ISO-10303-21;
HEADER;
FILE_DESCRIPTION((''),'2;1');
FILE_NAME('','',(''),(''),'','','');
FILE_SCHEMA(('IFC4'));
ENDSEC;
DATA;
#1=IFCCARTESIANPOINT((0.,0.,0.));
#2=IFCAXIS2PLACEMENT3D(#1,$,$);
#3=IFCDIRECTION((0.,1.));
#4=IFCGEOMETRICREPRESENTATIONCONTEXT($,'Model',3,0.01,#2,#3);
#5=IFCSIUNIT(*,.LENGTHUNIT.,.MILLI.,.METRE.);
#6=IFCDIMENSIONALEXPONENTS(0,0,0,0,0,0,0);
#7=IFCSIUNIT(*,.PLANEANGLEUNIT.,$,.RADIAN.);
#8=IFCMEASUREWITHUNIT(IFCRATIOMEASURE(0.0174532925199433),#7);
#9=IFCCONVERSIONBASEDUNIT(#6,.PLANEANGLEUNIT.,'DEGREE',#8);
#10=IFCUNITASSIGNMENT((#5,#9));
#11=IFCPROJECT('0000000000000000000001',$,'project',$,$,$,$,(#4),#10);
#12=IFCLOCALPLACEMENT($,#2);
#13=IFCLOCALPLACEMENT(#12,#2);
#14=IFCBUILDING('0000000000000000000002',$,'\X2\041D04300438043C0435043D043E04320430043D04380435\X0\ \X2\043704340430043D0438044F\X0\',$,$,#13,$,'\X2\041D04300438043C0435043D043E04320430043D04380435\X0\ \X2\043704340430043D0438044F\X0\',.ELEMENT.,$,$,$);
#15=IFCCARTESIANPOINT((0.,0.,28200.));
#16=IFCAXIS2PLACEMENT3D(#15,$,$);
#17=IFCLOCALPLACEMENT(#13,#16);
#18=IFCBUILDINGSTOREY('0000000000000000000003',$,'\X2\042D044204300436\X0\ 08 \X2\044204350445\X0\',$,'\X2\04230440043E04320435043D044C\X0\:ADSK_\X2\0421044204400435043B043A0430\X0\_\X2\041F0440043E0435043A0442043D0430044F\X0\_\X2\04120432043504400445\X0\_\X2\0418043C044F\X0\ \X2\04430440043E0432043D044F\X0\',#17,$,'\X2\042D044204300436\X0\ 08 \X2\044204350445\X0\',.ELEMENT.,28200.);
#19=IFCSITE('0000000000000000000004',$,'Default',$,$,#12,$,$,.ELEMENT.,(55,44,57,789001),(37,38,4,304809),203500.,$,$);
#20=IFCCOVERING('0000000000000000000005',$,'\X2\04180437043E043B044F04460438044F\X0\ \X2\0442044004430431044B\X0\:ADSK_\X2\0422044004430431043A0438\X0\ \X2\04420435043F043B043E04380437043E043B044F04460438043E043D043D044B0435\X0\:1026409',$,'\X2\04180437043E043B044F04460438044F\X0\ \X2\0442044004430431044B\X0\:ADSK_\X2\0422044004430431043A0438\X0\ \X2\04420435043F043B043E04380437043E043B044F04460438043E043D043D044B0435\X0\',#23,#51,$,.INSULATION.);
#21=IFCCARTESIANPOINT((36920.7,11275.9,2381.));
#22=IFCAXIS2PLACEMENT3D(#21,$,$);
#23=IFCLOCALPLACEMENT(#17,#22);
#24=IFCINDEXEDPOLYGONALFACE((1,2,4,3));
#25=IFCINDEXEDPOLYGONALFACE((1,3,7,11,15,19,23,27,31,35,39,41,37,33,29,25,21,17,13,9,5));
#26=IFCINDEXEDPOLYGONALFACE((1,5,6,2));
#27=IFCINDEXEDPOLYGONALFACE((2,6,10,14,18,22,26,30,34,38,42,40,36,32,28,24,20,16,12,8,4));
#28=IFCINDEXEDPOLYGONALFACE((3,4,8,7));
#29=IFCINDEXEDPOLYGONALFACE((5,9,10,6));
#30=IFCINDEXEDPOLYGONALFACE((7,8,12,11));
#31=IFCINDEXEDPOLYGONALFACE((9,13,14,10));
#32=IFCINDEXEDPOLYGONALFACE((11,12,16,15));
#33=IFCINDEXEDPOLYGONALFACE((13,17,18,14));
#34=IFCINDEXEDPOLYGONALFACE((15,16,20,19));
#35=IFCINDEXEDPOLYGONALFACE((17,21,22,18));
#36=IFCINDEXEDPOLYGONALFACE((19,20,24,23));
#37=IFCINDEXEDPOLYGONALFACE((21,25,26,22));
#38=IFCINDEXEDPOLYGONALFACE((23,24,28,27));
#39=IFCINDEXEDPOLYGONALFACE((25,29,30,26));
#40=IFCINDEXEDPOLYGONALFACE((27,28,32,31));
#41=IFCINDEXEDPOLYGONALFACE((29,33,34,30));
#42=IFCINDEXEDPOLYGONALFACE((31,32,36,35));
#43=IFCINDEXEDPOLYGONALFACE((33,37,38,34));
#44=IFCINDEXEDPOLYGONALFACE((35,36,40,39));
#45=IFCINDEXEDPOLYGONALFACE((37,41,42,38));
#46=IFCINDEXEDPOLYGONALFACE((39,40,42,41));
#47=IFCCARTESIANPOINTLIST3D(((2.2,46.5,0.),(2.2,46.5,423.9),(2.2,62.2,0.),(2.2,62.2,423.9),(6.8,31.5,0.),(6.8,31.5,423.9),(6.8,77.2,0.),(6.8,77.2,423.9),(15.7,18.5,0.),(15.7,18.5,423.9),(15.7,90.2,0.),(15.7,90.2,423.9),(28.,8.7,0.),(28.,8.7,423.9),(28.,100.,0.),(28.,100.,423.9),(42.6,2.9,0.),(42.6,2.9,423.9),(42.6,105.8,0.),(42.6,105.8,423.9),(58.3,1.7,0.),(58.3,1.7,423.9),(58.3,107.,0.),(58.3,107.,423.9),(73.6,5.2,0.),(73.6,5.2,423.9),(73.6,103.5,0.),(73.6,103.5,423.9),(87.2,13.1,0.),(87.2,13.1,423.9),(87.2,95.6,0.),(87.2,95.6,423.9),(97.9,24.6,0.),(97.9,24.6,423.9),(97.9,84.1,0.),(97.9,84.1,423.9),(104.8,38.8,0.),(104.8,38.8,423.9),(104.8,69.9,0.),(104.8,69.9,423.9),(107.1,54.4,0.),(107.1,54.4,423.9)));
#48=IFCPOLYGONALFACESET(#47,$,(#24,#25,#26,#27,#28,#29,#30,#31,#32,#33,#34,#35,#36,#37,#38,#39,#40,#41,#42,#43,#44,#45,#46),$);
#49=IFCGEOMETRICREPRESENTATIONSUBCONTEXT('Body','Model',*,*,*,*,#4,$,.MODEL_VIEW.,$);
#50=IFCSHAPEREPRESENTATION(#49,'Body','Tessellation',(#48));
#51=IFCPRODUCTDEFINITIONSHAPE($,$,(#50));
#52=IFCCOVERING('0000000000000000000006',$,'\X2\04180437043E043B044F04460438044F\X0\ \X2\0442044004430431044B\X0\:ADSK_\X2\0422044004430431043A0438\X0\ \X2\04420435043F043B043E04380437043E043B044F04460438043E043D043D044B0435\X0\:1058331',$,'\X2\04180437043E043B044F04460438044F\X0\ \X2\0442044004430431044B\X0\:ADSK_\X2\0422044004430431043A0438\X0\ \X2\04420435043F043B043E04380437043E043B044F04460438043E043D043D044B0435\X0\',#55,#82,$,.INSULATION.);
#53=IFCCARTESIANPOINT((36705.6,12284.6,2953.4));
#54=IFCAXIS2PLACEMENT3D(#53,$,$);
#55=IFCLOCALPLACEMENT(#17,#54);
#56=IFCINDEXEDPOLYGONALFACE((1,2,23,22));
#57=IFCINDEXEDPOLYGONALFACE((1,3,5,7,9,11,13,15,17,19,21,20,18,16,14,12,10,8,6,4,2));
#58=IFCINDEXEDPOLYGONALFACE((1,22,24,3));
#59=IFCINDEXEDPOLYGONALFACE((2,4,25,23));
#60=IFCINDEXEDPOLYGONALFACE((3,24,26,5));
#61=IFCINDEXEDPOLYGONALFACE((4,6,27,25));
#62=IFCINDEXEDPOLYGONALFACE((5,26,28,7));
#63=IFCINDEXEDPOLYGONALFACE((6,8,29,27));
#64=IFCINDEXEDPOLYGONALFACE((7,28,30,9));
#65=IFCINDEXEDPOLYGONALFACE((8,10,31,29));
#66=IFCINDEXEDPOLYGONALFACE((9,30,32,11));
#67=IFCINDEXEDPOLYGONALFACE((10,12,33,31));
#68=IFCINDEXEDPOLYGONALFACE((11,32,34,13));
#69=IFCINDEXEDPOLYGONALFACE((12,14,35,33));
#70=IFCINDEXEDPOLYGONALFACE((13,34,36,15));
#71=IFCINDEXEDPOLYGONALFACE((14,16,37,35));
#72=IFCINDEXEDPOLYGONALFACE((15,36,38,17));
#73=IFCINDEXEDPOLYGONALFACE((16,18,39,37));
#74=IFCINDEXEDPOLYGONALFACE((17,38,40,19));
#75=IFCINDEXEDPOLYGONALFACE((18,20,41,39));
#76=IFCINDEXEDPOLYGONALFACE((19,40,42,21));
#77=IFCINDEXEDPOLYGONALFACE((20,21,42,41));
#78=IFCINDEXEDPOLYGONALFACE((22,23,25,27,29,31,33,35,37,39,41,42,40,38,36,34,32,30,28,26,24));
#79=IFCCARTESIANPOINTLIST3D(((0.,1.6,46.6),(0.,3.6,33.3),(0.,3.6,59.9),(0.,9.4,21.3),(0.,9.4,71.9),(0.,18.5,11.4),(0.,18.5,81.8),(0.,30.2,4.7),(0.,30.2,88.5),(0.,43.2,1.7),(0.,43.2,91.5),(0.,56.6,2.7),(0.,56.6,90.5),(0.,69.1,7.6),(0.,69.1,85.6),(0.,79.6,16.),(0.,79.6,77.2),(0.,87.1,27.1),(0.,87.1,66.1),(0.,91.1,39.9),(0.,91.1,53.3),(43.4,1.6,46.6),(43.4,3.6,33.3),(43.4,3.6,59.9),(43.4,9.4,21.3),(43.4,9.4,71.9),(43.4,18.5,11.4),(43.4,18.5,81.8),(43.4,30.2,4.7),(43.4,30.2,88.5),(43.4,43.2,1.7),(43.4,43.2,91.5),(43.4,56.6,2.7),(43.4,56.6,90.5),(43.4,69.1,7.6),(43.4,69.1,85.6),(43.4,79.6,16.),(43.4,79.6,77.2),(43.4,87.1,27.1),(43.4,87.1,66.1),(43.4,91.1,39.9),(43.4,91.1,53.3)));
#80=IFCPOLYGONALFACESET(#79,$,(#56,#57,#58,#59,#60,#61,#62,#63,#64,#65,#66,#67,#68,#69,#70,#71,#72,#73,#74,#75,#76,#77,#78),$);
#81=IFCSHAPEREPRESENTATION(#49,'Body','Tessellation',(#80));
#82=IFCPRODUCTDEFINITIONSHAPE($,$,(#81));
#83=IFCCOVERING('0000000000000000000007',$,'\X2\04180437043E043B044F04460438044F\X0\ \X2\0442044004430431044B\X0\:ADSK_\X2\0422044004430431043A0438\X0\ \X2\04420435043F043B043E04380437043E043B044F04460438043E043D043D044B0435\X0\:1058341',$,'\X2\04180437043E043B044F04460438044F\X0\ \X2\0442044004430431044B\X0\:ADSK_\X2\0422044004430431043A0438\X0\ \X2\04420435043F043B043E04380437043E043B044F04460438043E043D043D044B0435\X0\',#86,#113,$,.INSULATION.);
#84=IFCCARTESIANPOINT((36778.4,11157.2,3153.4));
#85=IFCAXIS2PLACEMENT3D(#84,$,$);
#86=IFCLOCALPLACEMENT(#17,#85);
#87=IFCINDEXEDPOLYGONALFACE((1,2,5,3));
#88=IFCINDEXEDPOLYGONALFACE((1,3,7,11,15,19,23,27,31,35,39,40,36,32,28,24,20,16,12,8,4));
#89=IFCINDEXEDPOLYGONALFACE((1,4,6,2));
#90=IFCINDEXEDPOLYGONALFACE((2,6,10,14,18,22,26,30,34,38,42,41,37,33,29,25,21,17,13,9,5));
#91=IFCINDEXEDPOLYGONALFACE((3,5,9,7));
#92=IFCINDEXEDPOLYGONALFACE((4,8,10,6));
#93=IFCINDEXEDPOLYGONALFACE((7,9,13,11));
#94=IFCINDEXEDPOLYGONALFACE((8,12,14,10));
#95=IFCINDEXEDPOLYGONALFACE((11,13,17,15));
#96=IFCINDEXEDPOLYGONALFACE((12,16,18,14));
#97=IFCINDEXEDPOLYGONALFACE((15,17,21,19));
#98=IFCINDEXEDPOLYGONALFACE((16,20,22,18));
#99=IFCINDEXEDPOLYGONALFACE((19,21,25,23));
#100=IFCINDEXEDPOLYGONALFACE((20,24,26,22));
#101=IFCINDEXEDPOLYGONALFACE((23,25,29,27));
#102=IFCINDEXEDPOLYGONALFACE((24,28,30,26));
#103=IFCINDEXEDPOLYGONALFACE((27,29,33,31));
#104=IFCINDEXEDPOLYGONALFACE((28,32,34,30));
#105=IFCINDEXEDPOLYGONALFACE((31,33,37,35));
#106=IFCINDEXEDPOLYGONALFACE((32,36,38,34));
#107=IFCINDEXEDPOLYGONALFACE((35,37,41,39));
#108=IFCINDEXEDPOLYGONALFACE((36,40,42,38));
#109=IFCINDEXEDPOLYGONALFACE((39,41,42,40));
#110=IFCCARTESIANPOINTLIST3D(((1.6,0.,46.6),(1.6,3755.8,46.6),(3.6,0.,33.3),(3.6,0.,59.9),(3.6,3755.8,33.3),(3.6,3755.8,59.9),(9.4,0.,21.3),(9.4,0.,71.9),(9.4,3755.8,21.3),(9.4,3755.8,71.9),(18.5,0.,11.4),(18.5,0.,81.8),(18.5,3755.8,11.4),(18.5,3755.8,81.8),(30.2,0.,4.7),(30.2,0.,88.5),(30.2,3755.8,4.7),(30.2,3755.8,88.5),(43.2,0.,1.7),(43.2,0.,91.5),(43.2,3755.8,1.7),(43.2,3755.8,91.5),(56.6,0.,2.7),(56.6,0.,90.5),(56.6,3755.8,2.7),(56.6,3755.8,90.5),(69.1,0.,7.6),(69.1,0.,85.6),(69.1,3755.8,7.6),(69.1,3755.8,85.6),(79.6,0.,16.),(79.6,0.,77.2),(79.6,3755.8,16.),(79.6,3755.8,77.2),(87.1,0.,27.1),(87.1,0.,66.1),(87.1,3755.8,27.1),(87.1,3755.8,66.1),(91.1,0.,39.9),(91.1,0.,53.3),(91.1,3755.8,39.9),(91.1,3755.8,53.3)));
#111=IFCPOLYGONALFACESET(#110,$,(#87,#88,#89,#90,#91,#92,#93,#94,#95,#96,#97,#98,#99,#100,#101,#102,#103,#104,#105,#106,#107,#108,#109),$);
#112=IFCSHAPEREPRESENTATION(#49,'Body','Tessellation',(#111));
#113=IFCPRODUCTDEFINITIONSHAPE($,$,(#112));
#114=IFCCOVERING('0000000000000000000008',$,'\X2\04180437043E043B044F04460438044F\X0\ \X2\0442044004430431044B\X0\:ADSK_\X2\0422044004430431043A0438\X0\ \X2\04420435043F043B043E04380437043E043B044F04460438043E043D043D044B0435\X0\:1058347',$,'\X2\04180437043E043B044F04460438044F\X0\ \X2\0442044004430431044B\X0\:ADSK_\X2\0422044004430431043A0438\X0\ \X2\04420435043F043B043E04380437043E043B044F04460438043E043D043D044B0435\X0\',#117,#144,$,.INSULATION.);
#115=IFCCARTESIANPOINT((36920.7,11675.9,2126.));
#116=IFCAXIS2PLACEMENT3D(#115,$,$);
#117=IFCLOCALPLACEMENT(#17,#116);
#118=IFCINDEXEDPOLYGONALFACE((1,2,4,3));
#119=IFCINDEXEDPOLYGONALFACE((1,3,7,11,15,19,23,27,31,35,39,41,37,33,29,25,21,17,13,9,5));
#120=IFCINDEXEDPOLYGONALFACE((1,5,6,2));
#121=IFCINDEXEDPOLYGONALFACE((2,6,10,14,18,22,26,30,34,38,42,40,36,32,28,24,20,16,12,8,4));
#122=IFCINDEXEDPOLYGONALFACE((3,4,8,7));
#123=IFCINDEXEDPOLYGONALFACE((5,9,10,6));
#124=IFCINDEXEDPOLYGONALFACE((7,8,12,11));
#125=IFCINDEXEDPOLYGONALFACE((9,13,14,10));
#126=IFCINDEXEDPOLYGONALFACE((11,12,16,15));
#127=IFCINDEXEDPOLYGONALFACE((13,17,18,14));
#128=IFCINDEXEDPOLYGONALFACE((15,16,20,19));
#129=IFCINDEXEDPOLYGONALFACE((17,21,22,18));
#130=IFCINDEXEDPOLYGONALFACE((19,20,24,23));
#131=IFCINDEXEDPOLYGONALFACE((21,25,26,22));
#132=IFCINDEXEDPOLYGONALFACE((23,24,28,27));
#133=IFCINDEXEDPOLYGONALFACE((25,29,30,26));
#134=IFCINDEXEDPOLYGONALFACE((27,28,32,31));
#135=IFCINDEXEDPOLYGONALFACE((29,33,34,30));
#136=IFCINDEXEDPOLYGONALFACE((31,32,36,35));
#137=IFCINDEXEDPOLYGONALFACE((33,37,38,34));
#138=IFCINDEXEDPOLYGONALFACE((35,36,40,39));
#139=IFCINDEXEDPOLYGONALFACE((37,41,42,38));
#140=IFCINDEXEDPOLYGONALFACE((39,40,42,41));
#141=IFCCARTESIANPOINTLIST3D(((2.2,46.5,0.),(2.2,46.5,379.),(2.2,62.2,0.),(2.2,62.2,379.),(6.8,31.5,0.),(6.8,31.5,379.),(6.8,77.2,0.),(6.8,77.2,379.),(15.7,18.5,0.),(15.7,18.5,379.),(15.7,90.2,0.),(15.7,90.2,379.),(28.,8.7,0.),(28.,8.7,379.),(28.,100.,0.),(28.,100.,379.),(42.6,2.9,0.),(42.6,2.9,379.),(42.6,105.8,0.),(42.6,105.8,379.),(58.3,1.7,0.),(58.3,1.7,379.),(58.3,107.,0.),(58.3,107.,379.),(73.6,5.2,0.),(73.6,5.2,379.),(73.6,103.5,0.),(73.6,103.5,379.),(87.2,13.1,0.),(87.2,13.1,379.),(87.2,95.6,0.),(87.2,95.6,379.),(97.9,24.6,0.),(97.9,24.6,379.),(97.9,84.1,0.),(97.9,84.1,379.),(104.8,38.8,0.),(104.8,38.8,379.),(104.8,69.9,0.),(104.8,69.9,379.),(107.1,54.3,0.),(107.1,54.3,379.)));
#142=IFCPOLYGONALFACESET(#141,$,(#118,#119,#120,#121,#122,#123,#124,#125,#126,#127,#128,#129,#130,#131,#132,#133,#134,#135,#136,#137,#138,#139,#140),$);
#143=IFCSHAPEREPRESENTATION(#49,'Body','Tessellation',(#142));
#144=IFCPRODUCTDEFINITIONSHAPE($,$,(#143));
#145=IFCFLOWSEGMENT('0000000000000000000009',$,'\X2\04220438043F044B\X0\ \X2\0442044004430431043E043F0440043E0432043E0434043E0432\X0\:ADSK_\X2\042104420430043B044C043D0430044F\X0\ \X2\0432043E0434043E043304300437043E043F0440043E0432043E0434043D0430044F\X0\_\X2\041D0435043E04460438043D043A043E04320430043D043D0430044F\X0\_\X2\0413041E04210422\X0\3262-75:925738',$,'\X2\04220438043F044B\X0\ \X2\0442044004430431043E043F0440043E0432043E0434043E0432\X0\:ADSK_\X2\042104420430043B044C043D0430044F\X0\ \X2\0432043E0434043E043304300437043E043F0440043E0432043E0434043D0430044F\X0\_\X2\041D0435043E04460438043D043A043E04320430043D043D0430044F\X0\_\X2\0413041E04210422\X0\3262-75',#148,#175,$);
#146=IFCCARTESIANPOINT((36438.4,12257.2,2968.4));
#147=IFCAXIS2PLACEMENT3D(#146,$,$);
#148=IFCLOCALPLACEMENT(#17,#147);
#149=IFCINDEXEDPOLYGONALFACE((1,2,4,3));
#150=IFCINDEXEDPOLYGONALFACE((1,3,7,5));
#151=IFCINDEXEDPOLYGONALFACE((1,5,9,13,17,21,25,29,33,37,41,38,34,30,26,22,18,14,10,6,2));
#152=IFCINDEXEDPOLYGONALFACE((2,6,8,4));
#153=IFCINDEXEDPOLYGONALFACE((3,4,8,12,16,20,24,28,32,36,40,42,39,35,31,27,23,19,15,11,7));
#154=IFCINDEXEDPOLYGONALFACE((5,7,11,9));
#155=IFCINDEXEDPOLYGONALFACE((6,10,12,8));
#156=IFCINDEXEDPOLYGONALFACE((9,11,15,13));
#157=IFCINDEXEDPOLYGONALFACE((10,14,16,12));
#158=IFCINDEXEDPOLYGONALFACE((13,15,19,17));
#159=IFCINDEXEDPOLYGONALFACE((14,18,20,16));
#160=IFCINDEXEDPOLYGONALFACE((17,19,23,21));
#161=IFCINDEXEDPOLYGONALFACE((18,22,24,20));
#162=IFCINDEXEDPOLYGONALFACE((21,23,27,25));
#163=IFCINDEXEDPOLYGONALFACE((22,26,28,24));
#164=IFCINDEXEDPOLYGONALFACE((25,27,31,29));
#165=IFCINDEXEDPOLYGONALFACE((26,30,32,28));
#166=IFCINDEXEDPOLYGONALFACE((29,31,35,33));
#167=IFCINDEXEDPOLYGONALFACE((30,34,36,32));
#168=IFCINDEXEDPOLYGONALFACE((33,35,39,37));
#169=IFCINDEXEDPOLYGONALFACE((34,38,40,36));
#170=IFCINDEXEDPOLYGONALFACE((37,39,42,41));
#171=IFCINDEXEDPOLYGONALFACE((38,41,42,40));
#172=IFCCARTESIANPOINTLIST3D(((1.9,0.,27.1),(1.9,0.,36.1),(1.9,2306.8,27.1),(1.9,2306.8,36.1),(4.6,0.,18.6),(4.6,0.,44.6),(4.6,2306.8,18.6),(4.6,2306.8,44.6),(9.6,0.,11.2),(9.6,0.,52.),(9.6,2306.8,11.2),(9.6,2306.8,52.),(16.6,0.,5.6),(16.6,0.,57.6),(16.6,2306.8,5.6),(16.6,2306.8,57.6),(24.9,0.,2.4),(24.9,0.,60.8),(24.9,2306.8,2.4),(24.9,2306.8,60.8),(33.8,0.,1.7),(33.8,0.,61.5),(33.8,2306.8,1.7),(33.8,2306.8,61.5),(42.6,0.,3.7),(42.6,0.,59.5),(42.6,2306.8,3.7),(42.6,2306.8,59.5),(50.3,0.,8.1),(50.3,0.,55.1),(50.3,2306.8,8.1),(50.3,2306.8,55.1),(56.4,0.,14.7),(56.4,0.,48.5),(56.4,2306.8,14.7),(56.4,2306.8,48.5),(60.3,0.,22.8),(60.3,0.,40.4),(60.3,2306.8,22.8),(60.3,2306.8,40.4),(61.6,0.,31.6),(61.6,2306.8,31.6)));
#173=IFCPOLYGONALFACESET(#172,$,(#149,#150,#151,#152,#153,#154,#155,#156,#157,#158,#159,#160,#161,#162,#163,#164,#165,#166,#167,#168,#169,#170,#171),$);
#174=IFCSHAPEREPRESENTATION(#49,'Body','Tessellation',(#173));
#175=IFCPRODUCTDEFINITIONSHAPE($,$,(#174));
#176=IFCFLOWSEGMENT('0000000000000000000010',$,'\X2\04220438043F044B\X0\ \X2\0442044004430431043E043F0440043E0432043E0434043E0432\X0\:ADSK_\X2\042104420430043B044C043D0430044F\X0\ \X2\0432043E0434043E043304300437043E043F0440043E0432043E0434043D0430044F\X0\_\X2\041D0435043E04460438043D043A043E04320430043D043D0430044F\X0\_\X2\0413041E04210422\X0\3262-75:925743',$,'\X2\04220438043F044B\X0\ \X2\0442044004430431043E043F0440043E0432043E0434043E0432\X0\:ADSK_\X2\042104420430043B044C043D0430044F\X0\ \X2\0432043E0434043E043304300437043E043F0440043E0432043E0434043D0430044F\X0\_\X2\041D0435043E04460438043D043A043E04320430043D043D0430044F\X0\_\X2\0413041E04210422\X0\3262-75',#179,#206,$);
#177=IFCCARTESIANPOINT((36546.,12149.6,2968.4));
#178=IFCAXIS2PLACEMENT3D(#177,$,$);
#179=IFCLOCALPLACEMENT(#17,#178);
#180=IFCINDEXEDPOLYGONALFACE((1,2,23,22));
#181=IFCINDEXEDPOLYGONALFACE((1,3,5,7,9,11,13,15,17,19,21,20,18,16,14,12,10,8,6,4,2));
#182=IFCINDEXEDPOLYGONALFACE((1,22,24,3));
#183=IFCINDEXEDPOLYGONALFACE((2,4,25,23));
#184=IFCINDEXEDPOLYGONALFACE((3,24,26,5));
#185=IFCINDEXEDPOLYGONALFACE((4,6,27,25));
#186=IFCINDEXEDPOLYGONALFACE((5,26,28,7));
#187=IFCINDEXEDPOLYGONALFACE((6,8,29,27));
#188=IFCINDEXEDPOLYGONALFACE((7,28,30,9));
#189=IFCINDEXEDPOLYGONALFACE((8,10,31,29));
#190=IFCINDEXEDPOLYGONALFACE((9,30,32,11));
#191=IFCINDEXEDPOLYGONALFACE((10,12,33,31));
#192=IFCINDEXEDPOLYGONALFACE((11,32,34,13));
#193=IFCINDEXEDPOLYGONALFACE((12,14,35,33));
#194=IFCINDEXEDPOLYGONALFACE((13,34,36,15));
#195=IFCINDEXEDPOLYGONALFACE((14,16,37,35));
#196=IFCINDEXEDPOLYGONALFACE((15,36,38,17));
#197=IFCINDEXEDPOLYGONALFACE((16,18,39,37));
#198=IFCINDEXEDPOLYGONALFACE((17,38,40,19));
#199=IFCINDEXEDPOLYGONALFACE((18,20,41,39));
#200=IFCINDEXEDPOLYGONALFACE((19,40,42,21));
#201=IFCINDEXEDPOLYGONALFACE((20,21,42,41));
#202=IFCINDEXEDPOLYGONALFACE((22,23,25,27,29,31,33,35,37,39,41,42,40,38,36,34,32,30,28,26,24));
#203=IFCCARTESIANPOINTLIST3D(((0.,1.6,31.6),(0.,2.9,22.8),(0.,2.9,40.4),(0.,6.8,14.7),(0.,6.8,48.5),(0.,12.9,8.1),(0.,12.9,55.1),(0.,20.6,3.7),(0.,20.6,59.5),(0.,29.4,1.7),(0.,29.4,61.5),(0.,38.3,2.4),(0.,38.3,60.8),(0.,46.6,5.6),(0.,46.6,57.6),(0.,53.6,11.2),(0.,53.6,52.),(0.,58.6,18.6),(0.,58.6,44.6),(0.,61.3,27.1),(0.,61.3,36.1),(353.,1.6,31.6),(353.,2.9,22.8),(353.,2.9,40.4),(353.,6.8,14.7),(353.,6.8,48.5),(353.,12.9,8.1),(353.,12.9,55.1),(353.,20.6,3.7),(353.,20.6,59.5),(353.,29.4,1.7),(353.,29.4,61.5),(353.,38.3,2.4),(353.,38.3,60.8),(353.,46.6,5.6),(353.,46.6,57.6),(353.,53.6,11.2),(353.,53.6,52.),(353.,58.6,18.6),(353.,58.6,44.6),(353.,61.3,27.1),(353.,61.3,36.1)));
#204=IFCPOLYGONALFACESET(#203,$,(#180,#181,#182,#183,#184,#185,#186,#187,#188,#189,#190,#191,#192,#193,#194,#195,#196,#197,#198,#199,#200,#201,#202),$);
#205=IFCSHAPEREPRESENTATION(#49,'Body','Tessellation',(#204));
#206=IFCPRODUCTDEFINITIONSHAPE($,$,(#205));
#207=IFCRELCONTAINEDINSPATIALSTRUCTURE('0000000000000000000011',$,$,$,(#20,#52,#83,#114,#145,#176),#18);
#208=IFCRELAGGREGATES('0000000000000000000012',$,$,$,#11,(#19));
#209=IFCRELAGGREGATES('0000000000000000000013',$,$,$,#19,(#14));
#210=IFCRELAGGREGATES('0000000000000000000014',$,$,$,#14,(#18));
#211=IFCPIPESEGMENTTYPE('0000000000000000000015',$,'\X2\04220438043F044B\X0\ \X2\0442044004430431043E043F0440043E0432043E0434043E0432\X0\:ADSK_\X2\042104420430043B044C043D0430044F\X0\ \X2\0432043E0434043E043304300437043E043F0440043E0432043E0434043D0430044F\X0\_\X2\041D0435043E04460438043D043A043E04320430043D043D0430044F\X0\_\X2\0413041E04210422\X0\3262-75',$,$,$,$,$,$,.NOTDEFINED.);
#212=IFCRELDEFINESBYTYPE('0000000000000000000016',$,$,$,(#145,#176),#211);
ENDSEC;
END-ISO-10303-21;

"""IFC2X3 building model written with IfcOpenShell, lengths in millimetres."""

from ifc_helpers import new_model, entity, si_unit, converted_unit, direction, frame, origin, origin_2d_with_axis, place, context, subcontext, project, spatial, circle, extrude, type_object, element, save


model = new_model("IFC2X3")

# Units and contexts
model_context = context("Model", 3, precision=0.01, world=origin(), true_north=direction((0.0, 1.0)))
body_context = subcontext(model_context, "Body", "Model", "MODEL_VIEW")
ifc_project = project(units=[si_unit("LENGTHUNIT", "METRE", prefix="MILLI"), converted_unit("PLANEANGLEUNIT", "DEGREE", entity("IfcRatioMeasure", 0.0174532925199433), si_unit("PLANEANGLEUNIT", "RADIAN"), dimensions=[0, 0, 0, 0, 0, 0, 0])], contexts=[model_context])

# Site, building, storey
site_placement = place(None, origin())
site = spatial("IfcSite", under=ifc_project, at=site_placement, Name="Default", CompositionType="ELEMENT", RefLatitude=(55, 44, 57, 789001), RefLongitude=(37, 38, 4, 304809), RefElevation=203500.0)
building_placement = place(site_placement, origin())
building = spatial("IfcBuilding", under=site, at=building_placement, Name="Наименование здания", LongName="Наименование здания", CompositionType="ELEMENT")
storey_placement = place(building_placement, frame((0.0, 0.0, 28200.0)))
storey = spatial("IfcBuildingStorey", under=building, at=storey_placement, Name="Этаж 08 тех", ObjectType="Уровень:ADSK_Стрелка_Проектная_Вверх_Имя уровня", LongName="Этаж 08 тех", CompositionType="ELEMENT", Elevation=28200.0)

# Coverings
covering_1_placement = place(storey_placement, frame((36920.7, 11275.9, 2381.0)))
element("IfcCovering", 1, at=covering_1_placement, inside=storey, Name="Изоляция трубы:ADSK_Трубки теплоизоляционные:1026409", ObjectType="Изоляция трубы:ADSK_Трубки теплоизоляционные", PredefinedType="INSULATION", context=body_context, shape_type="SweptSolid", body=[
    extrude(circle(Radius=52.8, at=origin_2d_with_axis()), frame((54.4, 54.4, 0.0)), (0.0, 0.0, 1.0), 423.9),
])
covering_2_placement = place(storey_placement, frame((36705.6, 12284.6, 2953.4)))
element("IfcCovering", 2, at=covering_2_placement, inside=storey, Name="Изоляция трубы:ADSK_Трубки теплоизоляционные:1058331", ObjectType="Изоляция трубы:ADSK_Трубки теплоизоляционные", PredefinedType="INSULATION", context=body_context, shape_type="SweptSolid", body=[
    extrude(circle(Radius=45.0, at=origin_2d_with_axis()), frame((0.0, 46.6, 46.6), z_axis=(1.0, 0.0, 0.0), x_axis=(0.0, -1.0, 0.0)), (0.0, 0.0, 1.0), 43.4),
])
covering_3_placement = place(storey_placement, frame((36778.4, 11157.2, 3153.4)))
element("IfcCovering", 3, at=covering_3_placement, inside=storey, Name="Изоляция трубы:ADSK_Трубки теплоизоляционные:1058341", ObjectType="Изоляция трубы:ADSK_Трубки теплоизоляционные", PredefinedType="INSULATION", context=body_context, shape_type="SweptSolid", body=[
    extrude(circle(Radius=45.0, at=origin_2d_with_axis()), frame((46.6, 0.0, 46.6), z_axis=(0.0, 1.0, 0.0), x_axis=(-1.0, 0.0, 0.0)), (0.0, 0.0, 1.0), 3755.8),
])
covering_4_placement = place(storey_placement, frame((36920.7, 11675.9, 2126.0)))
element("IfcCovering", 4, at=covering_4_placement, inside=storey, Name="Изоляция трубы:ADSK_Трубки теплоизоляционные:1058347", ObjectType="Изоляция трубы:ADSK_Трубки теплоизоляционные", PredefinedType="INSULATION", context=body_context, shape_type="SweptSolid", body=[
    extrude(circle(Radius=52.8, at=origin_2d_with_axis()), frame((54.4, 54.4, 0.0)), (0.0, 0.0, 1.0), 379.0),
])

# Flow segments
pipe_segment_type = type_object("IfcPipeSegmentType", Name="Типы трубопроводов:ADSK_Стальная водогазопроводная_Неоцинкованная_ГОСТ3262-75", PredefinedType="NOTDEFINED")
flow_segment_1_placement = place(storey_placement, frame((36438.4, 12257.2, 2968.4)))
element("IfcFlowSegment", 5, at=flow_segment_1_placement, inside=storey, type_object=pipe_segment_type, Name="Типы трубопроводов:ADSK_Стальная водогазопроводная_Неоцинкованная_ГОСТ3262-75:925738", ObjectType="Типы трубопроводов:ADSK_Стальная водогазопроводная_Неоцинкованная_ГОСТ3262-75", context=body_context, shape_type="SweptSolid", body=[
    extrude(circle(Radius=30.0, at=origin_2d_with_axis()), frame((31.6, 0.0, 31.6), z_axis=(0.0, 1.0, 0.0), x_axis=(1.0, 0.0, 0.0)), (0.0, 0.0, 1.0), 2306.8),
])
flow_segment_2_placement = place(storey_placement, frame((36546.0, 12149.6, 2968.4)))
element("IfcFlowSegment", 6, at=flow_segment_2_placement, inside=storey, type_object=pipe_segment_type, Name="Типы трубопроводов:ADSK_Стальная водогазопроводная_Неоцинкованная_ГОСТ3262-75:925743", ObjectType="Типы трубопроводов:ADSK_Стальная водогазопроводная_Неоцинкованная_ГОСТ3262-75", context=body_context, shape_type="SweptSolid", body=[
    extrude(circle(Radius=30.0, at=origin_2d_with_axis()), frame((0.0, 31.6, 31.6), z_axis=(1.0, 0.0, 0.0), x_axis=(0.0, -1.0, 0.0)), (0.0, 0.0, 1.0), 353.0),
])

save(model, "model.ifc")
